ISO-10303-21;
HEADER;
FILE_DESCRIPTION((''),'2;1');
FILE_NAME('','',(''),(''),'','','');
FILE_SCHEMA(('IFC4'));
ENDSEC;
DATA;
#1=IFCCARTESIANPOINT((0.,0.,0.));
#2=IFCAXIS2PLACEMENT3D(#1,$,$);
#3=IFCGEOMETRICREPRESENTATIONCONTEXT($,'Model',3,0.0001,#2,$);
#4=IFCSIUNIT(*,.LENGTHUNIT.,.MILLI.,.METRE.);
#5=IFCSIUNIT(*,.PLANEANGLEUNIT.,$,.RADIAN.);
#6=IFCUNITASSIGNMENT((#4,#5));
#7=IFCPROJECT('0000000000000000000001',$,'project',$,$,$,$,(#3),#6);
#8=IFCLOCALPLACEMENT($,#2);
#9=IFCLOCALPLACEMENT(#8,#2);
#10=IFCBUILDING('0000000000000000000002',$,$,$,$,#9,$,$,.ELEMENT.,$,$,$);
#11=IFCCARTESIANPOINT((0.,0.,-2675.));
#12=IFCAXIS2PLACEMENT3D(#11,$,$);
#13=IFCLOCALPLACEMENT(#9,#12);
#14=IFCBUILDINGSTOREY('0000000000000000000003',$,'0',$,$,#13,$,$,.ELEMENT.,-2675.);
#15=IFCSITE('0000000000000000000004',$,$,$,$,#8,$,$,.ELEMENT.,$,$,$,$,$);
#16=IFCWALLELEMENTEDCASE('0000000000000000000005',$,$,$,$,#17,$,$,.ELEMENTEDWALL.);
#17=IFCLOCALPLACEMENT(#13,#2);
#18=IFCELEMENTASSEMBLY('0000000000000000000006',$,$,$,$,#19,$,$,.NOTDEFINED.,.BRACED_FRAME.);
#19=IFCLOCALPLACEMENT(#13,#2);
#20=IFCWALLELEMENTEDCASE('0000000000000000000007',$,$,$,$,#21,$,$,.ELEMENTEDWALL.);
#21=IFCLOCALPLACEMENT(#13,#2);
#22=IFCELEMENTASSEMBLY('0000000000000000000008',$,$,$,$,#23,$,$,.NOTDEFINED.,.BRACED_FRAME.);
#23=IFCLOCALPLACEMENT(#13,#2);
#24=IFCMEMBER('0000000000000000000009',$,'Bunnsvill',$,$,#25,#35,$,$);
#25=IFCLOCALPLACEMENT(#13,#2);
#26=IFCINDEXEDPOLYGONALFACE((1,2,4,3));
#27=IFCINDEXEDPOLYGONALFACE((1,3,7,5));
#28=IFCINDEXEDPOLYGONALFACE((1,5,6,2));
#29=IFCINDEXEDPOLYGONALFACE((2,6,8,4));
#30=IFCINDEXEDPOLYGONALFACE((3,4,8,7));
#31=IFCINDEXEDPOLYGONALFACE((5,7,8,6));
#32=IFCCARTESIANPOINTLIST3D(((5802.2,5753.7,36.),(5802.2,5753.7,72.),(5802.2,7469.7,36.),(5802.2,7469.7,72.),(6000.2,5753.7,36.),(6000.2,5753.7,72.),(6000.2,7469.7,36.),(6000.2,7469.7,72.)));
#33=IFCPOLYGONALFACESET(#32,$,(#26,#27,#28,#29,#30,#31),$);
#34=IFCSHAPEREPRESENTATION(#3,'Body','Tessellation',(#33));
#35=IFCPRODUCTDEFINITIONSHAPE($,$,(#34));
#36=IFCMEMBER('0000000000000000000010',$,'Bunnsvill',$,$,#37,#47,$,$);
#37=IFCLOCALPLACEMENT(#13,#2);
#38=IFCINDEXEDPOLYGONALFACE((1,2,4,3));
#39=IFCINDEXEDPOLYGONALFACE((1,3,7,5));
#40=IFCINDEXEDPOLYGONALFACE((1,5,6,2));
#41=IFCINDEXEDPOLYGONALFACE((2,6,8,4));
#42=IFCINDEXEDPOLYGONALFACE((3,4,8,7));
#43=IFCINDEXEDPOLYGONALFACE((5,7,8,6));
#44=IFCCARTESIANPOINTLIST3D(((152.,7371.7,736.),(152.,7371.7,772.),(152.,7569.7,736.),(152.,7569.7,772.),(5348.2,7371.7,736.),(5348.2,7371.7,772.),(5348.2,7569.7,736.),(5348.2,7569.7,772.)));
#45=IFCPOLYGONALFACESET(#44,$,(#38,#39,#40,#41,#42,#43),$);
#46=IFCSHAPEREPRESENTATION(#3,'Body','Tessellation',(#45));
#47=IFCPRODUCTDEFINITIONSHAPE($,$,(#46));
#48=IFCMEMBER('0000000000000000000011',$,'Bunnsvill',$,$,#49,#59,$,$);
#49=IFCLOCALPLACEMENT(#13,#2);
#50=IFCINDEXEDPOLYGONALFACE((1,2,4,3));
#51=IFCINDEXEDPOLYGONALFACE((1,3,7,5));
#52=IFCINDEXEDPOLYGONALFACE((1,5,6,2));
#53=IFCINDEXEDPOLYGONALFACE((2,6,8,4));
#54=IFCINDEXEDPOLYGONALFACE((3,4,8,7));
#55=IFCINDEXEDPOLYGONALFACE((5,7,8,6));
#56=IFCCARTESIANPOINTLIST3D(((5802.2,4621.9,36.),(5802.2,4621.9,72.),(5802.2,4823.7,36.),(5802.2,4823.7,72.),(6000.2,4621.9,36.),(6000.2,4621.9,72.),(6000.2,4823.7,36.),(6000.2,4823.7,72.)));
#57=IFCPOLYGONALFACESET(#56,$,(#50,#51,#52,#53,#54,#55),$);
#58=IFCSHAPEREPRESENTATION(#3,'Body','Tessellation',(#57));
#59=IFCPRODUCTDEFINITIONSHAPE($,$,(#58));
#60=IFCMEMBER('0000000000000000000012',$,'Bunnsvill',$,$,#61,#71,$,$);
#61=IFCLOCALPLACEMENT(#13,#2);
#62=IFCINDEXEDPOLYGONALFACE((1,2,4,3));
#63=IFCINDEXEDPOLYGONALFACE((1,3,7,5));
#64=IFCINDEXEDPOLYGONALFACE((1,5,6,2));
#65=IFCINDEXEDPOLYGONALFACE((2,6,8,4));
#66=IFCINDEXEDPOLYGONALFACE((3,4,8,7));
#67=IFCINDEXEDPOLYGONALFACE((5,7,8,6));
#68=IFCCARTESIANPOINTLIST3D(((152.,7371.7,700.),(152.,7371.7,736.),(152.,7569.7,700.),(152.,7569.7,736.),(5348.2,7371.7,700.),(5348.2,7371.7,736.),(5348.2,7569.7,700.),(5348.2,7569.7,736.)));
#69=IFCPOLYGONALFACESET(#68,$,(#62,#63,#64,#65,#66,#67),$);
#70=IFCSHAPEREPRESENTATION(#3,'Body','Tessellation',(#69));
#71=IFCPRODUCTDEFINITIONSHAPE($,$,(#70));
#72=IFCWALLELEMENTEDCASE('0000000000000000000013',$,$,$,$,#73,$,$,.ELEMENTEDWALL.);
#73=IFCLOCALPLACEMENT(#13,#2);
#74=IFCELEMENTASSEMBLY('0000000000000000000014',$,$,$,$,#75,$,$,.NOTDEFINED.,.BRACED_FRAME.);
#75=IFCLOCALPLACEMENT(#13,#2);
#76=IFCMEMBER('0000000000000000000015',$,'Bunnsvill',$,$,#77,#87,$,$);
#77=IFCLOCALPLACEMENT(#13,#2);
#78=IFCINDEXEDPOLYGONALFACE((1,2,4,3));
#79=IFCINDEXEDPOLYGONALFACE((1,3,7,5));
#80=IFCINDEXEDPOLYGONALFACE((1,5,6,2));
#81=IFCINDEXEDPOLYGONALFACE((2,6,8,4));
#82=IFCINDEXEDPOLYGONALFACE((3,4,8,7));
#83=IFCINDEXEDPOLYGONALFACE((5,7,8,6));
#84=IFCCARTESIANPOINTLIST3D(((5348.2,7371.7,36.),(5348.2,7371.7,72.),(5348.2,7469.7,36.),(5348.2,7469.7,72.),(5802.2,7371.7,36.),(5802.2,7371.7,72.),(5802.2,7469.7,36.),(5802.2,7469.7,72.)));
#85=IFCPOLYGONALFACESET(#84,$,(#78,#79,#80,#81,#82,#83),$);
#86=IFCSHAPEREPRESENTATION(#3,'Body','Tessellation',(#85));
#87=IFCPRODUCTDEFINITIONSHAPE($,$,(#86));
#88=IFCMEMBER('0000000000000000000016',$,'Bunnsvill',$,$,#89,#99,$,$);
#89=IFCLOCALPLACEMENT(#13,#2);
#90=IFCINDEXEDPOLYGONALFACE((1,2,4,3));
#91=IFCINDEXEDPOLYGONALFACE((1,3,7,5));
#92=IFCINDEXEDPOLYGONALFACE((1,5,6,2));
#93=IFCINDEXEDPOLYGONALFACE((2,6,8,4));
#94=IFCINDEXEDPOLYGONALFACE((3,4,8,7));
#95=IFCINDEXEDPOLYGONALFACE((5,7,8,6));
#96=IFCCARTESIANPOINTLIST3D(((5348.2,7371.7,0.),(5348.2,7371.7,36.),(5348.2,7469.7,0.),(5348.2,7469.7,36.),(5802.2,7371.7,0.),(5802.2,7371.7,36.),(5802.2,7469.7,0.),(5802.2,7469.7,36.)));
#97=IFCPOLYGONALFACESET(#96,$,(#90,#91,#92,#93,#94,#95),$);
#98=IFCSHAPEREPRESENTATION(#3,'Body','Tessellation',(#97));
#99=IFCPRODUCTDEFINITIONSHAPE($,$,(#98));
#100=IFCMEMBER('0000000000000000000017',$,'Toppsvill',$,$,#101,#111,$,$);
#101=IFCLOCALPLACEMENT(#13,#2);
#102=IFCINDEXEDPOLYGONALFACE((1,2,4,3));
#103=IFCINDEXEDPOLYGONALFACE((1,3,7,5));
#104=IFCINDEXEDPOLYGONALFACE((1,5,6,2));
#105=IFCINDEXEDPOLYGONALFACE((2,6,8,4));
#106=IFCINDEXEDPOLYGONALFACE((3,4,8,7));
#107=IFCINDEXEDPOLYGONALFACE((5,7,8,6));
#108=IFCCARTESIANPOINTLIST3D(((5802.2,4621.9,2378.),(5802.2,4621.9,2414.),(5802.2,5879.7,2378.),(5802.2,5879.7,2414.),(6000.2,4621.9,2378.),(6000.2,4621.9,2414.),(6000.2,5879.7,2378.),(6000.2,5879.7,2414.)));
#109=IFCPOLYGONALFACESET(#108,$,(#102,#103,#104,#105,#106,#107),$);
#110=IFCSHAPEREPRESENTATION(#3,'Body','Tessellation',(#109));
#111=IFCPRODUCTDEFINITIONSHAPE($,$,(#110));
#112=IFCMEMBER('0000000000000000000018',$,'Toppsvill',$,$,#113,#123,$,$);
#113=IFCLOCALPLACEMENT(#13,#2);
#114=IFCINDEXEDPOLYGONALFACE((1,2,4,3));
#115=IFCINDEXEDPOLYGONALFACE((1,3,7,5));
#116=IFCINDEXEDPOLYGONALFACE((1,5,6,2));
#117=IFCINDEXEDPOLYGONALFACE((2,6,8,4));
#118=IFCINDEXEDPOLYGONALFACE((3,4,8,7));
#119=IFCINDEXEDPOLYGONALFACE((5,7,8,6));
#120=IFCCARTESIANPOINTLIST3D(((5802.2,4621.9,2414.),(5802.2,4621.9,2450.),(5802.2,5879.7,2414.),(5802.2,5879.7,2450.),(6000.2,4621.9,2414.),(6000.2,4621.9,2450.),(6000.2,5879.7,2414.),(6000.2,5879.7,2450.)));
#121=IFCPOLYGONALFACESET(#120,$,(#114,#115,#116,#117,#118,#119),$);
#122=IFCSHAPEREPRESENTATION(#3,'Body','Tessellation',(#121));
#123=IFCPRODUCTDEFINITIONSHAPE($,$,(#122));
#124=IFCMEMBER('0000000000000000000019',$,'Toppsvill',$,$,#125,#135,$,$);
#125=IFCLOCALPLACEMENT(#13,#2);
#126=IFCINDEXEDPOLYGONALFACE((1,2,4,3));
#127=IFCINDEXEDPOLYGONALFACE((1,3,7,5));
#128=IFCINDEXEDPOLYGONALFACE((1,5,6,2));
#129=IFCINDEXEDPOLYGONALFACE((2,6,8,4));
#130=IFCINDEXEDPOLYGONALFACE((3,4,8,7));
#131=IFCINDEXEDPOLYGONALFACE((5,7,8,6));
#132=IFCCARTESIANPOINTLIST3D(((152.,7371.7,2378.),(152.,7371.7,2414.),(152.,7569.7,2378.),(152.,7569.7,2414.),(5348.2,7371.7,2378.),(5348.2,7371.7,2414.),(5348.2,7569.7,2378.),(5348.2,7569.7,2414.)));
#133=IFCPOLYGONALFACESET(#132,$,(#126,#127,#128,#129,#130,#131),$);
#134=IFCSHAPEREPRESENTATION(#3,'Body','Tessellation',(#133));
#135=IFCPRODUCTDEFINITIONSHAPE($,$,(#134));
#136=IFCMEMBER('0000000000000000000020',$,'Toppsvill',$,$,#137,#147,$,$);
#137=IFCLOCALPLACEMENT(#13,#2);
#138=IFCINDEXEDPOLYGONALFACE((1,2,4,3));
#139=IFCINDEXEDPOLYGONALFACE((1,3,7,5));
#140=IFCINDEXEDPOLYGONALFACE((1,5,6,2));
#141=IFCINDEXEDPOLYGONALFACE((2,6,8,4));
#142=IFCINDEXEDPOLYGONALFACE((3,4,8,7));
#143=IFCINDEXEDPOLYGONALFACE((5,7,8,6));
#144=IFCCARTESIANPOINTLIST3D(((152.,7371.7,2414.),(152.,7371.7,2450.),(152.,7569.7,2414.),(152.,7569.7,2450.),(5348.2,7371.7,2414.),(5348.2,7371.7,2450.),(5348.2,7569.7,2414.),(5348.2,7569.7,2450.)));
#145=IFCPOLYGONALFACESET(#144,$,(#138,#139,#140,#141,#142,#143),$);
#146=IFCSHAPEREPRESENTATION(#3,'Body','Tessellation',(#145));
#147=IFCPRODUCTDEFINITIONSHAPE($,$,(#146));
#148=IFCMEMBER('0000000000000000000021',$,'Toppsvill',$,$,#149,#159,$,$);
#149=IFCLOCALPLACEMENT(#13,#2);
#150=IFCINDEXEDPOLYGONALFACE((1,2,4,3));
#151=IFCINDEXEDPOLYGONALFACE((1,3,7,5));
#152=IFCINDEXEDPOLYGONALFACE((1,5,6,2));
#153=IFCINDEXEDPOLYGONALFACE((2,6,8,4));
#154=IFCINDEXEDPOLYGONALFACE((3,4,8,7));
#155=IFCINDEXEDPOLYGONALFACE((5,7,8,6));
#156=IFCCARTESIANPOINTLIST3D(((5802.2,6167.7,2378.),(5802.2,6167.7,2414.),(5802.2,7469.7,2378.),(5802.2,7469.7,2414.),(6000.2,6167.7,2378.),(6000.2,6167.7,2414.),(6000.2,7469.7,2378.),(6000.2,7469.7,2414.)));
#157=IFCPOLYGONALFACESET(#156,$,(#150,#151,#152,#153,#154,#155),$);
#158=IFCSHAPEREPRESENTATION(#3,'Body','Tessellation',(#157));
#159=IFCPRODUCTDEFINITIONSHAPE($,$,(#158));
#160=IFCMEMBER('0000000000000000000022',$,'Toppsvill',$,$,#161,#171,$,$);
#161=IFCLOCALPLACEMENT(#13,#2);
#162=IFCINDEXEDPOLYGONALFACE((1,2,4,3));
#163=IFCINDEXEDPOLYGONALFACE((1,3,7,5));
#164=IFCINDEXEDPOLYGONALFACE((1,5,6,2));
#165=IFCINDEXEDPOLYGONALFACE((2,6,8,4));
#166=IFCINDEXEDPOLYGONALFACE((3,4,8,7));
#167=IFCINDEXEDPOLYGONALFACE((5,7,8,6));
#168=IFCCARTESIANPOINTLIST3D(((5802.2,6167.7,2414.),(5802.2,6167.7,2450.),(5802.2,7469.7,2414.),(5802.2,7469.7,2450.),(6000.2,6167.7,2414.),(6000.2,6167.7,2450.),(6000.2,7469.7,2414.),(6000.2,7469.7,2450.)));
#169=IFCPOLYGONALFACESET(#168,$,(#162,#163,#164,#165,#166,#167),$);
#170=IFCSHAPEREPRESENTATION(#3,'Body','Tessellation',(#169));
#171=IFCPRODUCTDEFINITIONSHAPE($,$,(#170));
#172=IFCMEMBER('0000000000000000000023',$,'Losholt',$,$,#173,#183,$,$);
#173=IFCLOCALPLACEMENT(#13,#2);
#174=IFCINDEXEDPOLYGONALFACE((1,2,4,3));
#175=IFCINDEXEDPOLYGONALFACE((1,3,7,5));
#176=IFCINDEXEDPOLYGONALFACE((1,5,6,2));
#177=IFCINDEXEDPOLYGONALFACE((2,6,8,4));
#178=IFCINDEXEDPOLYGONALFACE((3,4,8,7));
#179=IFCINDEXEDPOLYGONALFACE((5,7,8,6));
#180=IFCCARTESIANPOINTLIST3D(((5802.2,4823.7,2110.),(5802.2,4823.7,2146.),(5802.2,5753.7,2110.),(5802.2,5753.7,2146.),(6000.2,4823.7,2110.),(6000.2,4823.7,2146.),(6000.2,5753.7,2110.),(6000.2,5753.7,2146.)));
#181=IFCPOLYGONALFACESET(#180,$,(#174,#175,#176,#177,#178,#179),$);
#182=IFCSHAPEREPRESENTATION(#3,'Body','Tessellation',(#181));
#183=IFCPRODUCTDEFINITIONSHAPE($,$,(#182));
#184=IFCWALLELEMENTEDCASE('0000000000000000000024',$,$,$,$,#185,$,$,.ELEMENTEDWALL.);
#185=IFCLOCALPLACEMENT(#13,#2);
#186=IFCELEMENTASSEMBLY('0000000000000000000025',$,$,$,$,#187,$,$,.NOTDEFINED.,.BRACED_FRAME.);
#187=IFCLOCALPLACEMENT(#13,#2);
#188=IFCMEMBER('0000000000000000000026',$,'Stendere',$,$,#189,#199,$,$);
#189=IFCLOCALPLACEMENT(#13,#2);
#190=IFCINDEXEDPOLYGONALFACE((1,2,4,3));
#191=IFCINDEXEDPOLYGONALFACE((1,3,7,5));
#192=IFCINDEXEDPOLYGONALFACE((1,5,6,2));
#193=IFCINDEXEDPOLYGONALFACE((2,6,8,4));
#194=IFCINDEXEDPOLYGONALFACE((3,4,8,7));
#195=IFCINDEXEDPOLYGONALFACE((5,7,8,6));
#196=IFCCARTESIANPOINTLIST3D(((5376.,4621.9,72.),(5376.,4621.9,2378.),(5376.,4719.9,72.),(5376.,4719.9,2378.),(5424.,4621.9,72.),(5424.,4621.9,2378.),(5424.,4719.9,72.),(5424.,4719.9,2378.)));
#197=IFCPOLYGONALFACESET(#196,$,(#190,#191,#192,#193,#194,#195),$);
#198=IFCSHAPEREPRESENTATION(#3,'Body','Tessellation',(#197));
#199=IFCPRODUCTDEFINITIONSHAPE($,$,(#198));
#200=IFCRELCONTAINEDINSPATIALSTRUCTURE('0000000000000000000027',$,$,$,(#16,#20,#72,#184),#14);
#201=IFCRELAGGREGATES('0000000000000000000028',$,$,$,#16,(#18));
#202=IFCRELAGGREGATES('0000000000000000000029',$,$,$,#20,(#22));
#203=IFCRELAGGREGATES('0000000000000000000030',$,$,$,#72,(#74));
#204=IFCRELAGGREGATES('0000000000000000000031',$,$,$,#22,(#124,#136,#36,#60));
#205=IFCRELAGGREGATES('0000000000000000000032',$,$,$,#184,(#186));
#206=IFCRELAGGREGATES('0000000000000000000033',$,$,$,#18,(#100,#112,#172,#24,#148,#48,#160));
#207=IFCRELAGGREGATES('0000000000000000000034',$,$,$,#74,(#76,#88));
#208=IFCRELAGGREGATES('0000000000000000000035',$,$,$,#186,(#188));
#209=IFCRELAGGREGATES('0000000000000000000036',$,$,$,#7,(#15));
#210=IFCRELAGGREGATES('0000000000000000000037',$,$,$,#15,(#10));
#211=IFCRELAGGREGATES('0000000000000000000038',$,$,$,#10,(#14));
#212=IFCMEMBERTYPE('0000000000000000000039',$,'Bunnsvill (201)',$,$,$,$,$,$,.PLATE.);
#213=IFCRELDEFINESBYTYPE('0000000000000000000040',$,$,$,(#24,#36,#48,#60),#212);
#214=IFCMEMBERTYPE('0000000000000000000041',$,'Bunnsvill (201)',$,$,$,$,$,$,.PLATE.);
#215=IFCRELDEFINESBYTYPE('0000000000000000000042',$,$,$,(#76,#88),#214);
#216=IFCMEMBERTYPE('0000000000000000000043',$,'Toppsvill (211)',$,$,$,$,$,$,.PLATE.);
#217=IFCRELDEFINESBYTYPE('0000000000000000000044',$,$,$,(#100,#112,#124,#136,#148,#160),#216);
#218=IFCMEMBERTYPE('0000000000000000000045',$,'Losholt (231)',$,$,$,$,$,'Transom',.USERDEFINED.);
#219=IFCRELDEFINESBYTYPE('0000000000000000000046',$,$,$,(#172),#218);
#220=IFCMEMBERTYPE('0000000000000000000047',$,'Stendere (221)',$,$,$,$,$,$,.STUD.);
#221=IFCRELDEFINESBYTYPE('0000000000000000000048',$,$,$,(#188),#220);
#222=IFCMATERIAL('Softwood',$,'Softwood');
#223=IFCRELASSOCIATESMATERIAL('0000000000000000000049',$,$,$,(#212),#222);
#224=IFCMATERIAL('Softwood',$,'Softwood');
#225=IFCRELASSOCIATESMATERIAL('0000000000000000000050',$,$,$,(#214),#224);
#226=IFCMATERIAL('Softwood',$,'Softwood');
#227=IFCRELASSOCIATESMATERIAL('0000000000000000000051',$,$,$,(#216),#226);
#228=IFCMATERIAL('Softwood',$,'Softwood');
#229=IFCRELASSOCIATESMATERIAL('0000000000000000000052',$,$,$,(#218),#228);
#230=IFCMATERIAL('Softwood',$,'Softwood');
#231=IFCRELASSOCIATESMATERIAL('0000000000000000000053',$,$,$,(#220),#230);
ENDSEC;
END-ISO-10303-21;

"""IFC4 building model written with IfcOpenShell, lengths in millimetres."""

from ifc_helpers import new_model, si_unit, frame, origin, place, context, project, spatial, rectangle, extrude, clip, halfspace, material, material_profile, profile_set, type_object, element, aggregate, save


model = new_model("IFC4")

# Units and contexts
model_context = context("Model", 3, precision=0.0001, world=origin())
ifc_project = project(units=[si_unit("LENGTHUNIT", "METRE", prefix="MILLI"), si_unit("PLANEANGLEUNIT", "RADIAN")], contexts=[model_context])

# Site, building, storey
site_placement = place(None, origin())
site = spatial("IfcSite", under=ifc_project, at=site_placement, CompositionType="ELEMENT")
building_placement = place(site_placement, origin())
building = spatial("IfcBuilding", under=site, at=building_placement, CompositionType="ELEMENT")
storey_placement = place(building_placement, frame((0.0, 0.0, -2675.0)))
storey = spatial("IfcBuildingStorey", under=building, at=storey_placement, Name="0", CompositionType="ELEMENT", Elevation=-2675.0)

# Wall, element assembly
wall_1_placement = place(storey_placement, frame((6000.2, 7469.7, 0.0), z_axis=(-1.0, 0.0, 0.0), x_axis=(0.0, -1.0, 0.0)))
wall_1 = element("IfcWallElementedCase", 1, at=wall_1_placement, inside=storey, PredefinedType="ELEMENTEDWALL")
assembly_1_placement = place(wall_1_placement, origin())
assembly_1 = element("IfcElementAssembly", 2, at=assembly_1_placement, AssemblyPlace="NOTDEFINED", PredefinedType="BRACED_FRAME")
aggregate(wall_1, [assembly_1])

# Wall, element assembly
wall_2_placement = place(storey_placement, frame((5348.2, 7371.7, 700.0), z_axis=(0.0, 1.0, 0.0), x_axis=(-1.0, 0.0, 0.0)))
wall_2 = element("IfcWallElementedCase", 3, at=wall_2_placement, inside=storey, PredefinedType="ELEMENTEDWALL")
assembly_2_placement = place(wall_2_placement, origin())
assembly_2 = element("IfcElementAssembly", 4, at=assembly_2_placement, AssemblyPlace="NOTDEFINED", PredefinedType="BRACED_FRAME")
aggregate(wall_2, [assembly_2])

# Members
ifc_material_1 = material(Name="Softwood", Category="Softwood")
ifc_material_profile_1 = material_profile(ifc_material_1, rectangle(XDim=36.0, YDim=198.0), Name="Bunnsvill (201)")
ifc_profile_set_1 = profile_set([ifc_material_profile_1])
member_type_1 = type_object("IfcMemberType", Name="Bunnsvill (201)", PredefinedType="PLATE", material=ifc_profile_set_1)
member_1_placement = place(assembly_1_placement, frame((0.0, 54.0, 0.0), z_axis=(1.0, 0.0, 0.0), x_axis=(0.0, 1.0, 0.0)))
member_1 = element("IfcMember", 5, at=member_1_placement, type_object=member_type_1, Name="Bunnsvill", context=model_context, shape_type="SweptSolid", body=[
    extrude(rectangle(XDim=36.0, YDim=198.0), frame((0.0, 99.0, 0.0)), (0.0, 0.0, 1.0), 1716.0),
])
member_2_placement = place(assembly_2_placement, frame((0.0, 54.0, 0.0), z_axis=(1.0, 0.0, 0.0), x_axis=(0.0, 1.0, 0.0)))
member_2 = element("IfcMember", 6, at=member_2_placement, type_object=member_type_1, Name="Bunnsvill", context=model_context, shape_type="SweptSolid", body=[
    extrude(rectangle(XDim=36.0, YDim=198.0), frame((0.0, 99.0, 0.0)), (0.0, 0.0, 1.0), 5196.2),
])
member_3_placement = place(assembly_1_placement, frame((2646.0, 54.0, 0.0), z_axis=(1.0, 0.0, 0.0), x_axis=(0.0, 1.0, 0.0)))
member_3 = element("IfcMember", 7, at=member_3_placement, type_object=member_type_1, Name="Bunnsvill", context=model_context, shape_type="SweptSolid", body=[
    extrude(rectangle(XDim=36.0, YDim=198.0), frame((0.0, 99.0, 0.0)), (0.0, 0.0, 1.0), 201.8),
])
member_4_placement = place(assembly_2_placement, frame((0.0, 18.0, 0.0), z_axis=(1.0, 0.0, 0.0), x_axis=(0.0, 1.0, 0.0)))
member_4 = element("IfcMember", 8, at=member_4_placement, type_object=member_type_1, Name="Bunnsvill", context=model_context, shape_type="SweptSolid", body=[
    extrude(rectangle(XDim=36.0, YDim=198.0), frame((0.0, 99.0, 0.0)), (0.0, 0.0, 1.0), 5196.2),
])

# Wall, element assembly, members
wall_3_placement = place(storey_placement, frame((5802.2, 7371.7, 0.0), z_axis=(0.0, 1.0, 0.0), x_axis=(-1.0, 0.0, 0.0)))
wall_3 = element("IfcWallElementedCase", 9, at=wall_3_placement, inside=storey, PredefinedType="ELEMENTEDWALL")
assembly_3_placement = place(wall_3_placement, origin())
assembly_3 = element("IfcElementAssembly", 10, at=assembly_3_placement, AssemblyPlace="NOTDEFINED", PredefinedType="BRACED_FRAME")
aggregate(wall_3, [assembly_3])
ifc_material_2 = material(Name="Softwood", Category="Softwood")
ifc_material_profile_2 = material_profile(ifc_material_2, rectangle(XDim=36.0, YDim=98.0), Name="Bunnsvill (201)")
ifc_profile_set_2 = profile_set([ifc_material_profile_2])
member_type_2 = type_object("IfcMemberType", Name="Bunnsvill (201)", PredefinedType="PLATE", material=ifc_profile_set_2)
member_5_placement = place(assembly_3_placement, frame((0.0, 54.0, 0.0), z_axis=(1.0, 0.0, 0.0), x_axis=(0.0, 1.0, 0.0)))
member_5 = element("IfcMember", 11, at=member_5_placement, type_object=member_type_2, Name="Bunnsvill", context=model_context, shape_type="SweptSolid", body=[
    extrude(rectangle(XDim=36.0, YDim=98.0), frame((0.0, 49.0, 0.0)), (0.0, 0.0, 1.0), 454.0),
])
member_6_placement = place(assembly_3_placement, frame((0.0, 18.0, 0.0), z_axis=(1.0, 0.0, 0.0), x_axis=(0.0, 1.0, 0.0)))
member_6 = element("IfcMember", 12, at=member_6_placement, type_object=member_type_2, Name="Bunnsvill", context=model_context, shape_type="SweptSolid", body=[
    extrude(rectangle(XDim=36.0, YDim=98.0), frame((0.0, 49.0, 0.0)), (0.0, 0.0, 1.0), 454.0),
])

# Members
ifc_material_3 = material(Name="Softwood", Category="Softwood")
ifc_material_profile_3 = material_profile(ifc_material_3, rectangle(XDim=36.0, YDim=198.0), Name="Toppsvill (211)")
ifc_profile_set_3 = profile_set([ifc_material_profile_3])
member_type_3 = type_object("IfcMemberType", Name="Toppsvill (211)", PredefinedType="PLATE", material=ifc_profile_set_3)
member_7_placement = place(assembly_1_placement, frame((1590.0, 2396.0, 0.0), z_axis=(1.0, 0.0, 0.0), x_axis=(0.0, 1.0, 0.0)))
member_7 = element("IfcMember", 13, at=member_7_placement, type_object=member_type_3, Name="Toppsvill", context=model_context, shape_type="SweptSolid", body=[
    extrude(rectangle(XDim=36.0, YDim=198.0), frame((0.0, 99.0, 0.0)), (0.0, 0.0, 1.0), 1257.8),
])
member_8_placement = place(assembly_1_placement, frame((1590.0, 2432.0, 0.0), z_axis=(1.0, 0.0, 0.0), x_axis=(0.0, 1.0, 0.0)))
member_8 = element("IfcMember", 14, at=member_8_placement, type_object=member_type_3, Name="Toppsvill", context=model_context, shape_type="SweptSolid", body=[
    extrude(rectangle(XDim=36.0, YDim=198.0), frame((0.0, 99.0, 0.0)), (0.0, 0.0, 1.0), 1257.8),
])
member_9_placement = place(assembly_2_placement, frame((0.0, 1696.0, 0.0), z_axis=(1.0, 0.0, 0.0), x_axis=(0.0, 1.0, 0.0)))
member_9 = element("IfcMember", 15, at=member_9_placement, type_object=member_type_3, Name="Toppsvill", context=model_context, shape_type="SweptSolid", body=[
    extrude(rectangle(XDim=36.0, YDim=198.0), frame((0.0, 99.0, 0.0)), (0.0, 0.0, 1.0), 5196.2),
])
member_10_placement = place(assembly_2_placement, frame((0.0, 1732.0, 0.0), z_axis=(1.0, 0.0, 0.0), x_axis=(0.0, 1.0, 0.0)))
member_10 = element("IfcMember", 16, at=member_10_placement, type_object=member_type_3, Name="Toppsvill", context=model_context, shape_type="SweptSolid", body=[
    extrude(rectangle(XDim=36.0, YDim=198.0), frame((0.0, 99.0, 0.0)), (0.0, 0.0, 1.0), 5196.2),
])
aggregate(assembly_2, [member_9, member_10, member_2, member_4])
member_11_placement = place(assembly_1_placement, frame((0.0, 2396.0, 0.0), z_axis=(1.0, 0.0, 0.0), x_axis=(0.0, 1.0, 0.0)))
member_11 = element("IfcMember", 17, at=member_11_placement, type_object=member_type_3, Name="Toppsvill", context=model_context, shape_type="Clipping", body=[
    clip(extrude(rectangle(XDim=36.0, YDim=198.0), frame((0.0, 99.0, 0.0)), (0.0, 0.0, 1.0), 1302.0), halfspace(frame((0.0, 99.0, 0.0)), True)),
])
member_12_placement = place(assembly_1_placement, frame((0.0, 2432.0, 0.0), z_axis=(1.0, 0.0, 0.0), x_axis=(0.0, 1.0, 0.0)))
member_12 = element("IfcMember", 18, at=member_12_placement, type_object=member_type_3, Name="Toppsvill", context=model_context, shape_type="Clipping", body=[
    clip(extrude(rectangle(XDim=36.0, YDim=198.0), frame((0.0, 99.0, 0.0)), (0.0, 0.0, 1.0), 1302.0), halfspace(frame((0.0, 99.0, 0.0)), True)),
])
ifc_material_4 = material(Name="Softwood", Category="Softwood")
ifc_material_profile_4 = material_profile(ifc_material_4, rectangle(XDim=36.0, YDim=198.0), Name="Losholt (231)")
ifc_profile_set_4 = profile_set([ifc_material_profile_4])
member_type_4 = type_object("IfcMemberType", Name="Losholt (231)", ElementType="Transom", PredefinedType="USERDEFINED", material=ifc_profile_set_4)
member_13_placement = place(assembly_1_placement, frame((1716.0, 2128.0, 0.0), z_axis=(1.0, 0.0, 0.0), x_axis=(0.0, 1.0, 0.0)))
member_13 = element("IfcMember", 19, at=member_13_placement, type_object=member_type_4, Name="Losholt", context=model_context, shape_type="SweptSolid", body=[
    extrude(rectangle(XDim=36.0, YDim=198.0), frame((0.0, 99.0, 0.0)), (0.0, 0.0, 1.0), 930.0),
])

# Wall, element assembly, member
wall_4_placement = place(storey_placement, frame((352.0, 4719.9, 0.0), z_axis=(0.0, -1.0, 0.0)))
wall_4 = element("IfcWallElementedCase", 20, at=wall_4_placement, inside=storey, PredefinedType="ELEMENTEDWALL")
assembly_4_placement = place(wall_4_placement, origin())
assembly_4 = element("IfcElementAssembly", 21, at=assembly_4_placement, AssemblyPlace="NOTDEFINED", PredefinedType="BRACED_FRAME")
aggregate(wall_4, [assembly_4])
ifc_material_5 = material(Name="Softwood", Category="Softwood")
ifc_material_profile_5 = material_profile(ifc_material_5, rectangle(XDim=48.0, YDim=98.0), Name="Stendere (221)")
ifc_profile_set_5 = profile_set([ifc_material_profile_5])
member_type_5 = type_object("IfcMemberType", Name="Stendere (221)", PredefinedType="STUD", material=ifc_profile_set_5)
member_14_placement = place(assembly_4_placement, frame((5048.0, 72.0, 0.0), z_axis=(0.0, 1.0, 0.0), x_axis=(-1.0, 0.0, 0.0)))
member_14 = element("IfcMember", 22, at=member_14_placement, type_object=member_type_5, Name="Stendere", context=model_context, shape_type="Clipping", body=[
    clip(extrude(rectangle(XDim=48.0, YDim=98.0), frame((0.0, 49.0, 0.0)), (0.0, 0.0, 1.0), 2306.0), halfspace(frame((0.0, 49.0, 0.0)), True)),
])

aggregate(assembly_1, [member_7, member_8, member_13, member_1, member_11, member_3, member_12])
aggregate(assembly_3, [member_5, member_6])
aggregate(assembly_4, [member_14])

save(model, "model.ifc")
